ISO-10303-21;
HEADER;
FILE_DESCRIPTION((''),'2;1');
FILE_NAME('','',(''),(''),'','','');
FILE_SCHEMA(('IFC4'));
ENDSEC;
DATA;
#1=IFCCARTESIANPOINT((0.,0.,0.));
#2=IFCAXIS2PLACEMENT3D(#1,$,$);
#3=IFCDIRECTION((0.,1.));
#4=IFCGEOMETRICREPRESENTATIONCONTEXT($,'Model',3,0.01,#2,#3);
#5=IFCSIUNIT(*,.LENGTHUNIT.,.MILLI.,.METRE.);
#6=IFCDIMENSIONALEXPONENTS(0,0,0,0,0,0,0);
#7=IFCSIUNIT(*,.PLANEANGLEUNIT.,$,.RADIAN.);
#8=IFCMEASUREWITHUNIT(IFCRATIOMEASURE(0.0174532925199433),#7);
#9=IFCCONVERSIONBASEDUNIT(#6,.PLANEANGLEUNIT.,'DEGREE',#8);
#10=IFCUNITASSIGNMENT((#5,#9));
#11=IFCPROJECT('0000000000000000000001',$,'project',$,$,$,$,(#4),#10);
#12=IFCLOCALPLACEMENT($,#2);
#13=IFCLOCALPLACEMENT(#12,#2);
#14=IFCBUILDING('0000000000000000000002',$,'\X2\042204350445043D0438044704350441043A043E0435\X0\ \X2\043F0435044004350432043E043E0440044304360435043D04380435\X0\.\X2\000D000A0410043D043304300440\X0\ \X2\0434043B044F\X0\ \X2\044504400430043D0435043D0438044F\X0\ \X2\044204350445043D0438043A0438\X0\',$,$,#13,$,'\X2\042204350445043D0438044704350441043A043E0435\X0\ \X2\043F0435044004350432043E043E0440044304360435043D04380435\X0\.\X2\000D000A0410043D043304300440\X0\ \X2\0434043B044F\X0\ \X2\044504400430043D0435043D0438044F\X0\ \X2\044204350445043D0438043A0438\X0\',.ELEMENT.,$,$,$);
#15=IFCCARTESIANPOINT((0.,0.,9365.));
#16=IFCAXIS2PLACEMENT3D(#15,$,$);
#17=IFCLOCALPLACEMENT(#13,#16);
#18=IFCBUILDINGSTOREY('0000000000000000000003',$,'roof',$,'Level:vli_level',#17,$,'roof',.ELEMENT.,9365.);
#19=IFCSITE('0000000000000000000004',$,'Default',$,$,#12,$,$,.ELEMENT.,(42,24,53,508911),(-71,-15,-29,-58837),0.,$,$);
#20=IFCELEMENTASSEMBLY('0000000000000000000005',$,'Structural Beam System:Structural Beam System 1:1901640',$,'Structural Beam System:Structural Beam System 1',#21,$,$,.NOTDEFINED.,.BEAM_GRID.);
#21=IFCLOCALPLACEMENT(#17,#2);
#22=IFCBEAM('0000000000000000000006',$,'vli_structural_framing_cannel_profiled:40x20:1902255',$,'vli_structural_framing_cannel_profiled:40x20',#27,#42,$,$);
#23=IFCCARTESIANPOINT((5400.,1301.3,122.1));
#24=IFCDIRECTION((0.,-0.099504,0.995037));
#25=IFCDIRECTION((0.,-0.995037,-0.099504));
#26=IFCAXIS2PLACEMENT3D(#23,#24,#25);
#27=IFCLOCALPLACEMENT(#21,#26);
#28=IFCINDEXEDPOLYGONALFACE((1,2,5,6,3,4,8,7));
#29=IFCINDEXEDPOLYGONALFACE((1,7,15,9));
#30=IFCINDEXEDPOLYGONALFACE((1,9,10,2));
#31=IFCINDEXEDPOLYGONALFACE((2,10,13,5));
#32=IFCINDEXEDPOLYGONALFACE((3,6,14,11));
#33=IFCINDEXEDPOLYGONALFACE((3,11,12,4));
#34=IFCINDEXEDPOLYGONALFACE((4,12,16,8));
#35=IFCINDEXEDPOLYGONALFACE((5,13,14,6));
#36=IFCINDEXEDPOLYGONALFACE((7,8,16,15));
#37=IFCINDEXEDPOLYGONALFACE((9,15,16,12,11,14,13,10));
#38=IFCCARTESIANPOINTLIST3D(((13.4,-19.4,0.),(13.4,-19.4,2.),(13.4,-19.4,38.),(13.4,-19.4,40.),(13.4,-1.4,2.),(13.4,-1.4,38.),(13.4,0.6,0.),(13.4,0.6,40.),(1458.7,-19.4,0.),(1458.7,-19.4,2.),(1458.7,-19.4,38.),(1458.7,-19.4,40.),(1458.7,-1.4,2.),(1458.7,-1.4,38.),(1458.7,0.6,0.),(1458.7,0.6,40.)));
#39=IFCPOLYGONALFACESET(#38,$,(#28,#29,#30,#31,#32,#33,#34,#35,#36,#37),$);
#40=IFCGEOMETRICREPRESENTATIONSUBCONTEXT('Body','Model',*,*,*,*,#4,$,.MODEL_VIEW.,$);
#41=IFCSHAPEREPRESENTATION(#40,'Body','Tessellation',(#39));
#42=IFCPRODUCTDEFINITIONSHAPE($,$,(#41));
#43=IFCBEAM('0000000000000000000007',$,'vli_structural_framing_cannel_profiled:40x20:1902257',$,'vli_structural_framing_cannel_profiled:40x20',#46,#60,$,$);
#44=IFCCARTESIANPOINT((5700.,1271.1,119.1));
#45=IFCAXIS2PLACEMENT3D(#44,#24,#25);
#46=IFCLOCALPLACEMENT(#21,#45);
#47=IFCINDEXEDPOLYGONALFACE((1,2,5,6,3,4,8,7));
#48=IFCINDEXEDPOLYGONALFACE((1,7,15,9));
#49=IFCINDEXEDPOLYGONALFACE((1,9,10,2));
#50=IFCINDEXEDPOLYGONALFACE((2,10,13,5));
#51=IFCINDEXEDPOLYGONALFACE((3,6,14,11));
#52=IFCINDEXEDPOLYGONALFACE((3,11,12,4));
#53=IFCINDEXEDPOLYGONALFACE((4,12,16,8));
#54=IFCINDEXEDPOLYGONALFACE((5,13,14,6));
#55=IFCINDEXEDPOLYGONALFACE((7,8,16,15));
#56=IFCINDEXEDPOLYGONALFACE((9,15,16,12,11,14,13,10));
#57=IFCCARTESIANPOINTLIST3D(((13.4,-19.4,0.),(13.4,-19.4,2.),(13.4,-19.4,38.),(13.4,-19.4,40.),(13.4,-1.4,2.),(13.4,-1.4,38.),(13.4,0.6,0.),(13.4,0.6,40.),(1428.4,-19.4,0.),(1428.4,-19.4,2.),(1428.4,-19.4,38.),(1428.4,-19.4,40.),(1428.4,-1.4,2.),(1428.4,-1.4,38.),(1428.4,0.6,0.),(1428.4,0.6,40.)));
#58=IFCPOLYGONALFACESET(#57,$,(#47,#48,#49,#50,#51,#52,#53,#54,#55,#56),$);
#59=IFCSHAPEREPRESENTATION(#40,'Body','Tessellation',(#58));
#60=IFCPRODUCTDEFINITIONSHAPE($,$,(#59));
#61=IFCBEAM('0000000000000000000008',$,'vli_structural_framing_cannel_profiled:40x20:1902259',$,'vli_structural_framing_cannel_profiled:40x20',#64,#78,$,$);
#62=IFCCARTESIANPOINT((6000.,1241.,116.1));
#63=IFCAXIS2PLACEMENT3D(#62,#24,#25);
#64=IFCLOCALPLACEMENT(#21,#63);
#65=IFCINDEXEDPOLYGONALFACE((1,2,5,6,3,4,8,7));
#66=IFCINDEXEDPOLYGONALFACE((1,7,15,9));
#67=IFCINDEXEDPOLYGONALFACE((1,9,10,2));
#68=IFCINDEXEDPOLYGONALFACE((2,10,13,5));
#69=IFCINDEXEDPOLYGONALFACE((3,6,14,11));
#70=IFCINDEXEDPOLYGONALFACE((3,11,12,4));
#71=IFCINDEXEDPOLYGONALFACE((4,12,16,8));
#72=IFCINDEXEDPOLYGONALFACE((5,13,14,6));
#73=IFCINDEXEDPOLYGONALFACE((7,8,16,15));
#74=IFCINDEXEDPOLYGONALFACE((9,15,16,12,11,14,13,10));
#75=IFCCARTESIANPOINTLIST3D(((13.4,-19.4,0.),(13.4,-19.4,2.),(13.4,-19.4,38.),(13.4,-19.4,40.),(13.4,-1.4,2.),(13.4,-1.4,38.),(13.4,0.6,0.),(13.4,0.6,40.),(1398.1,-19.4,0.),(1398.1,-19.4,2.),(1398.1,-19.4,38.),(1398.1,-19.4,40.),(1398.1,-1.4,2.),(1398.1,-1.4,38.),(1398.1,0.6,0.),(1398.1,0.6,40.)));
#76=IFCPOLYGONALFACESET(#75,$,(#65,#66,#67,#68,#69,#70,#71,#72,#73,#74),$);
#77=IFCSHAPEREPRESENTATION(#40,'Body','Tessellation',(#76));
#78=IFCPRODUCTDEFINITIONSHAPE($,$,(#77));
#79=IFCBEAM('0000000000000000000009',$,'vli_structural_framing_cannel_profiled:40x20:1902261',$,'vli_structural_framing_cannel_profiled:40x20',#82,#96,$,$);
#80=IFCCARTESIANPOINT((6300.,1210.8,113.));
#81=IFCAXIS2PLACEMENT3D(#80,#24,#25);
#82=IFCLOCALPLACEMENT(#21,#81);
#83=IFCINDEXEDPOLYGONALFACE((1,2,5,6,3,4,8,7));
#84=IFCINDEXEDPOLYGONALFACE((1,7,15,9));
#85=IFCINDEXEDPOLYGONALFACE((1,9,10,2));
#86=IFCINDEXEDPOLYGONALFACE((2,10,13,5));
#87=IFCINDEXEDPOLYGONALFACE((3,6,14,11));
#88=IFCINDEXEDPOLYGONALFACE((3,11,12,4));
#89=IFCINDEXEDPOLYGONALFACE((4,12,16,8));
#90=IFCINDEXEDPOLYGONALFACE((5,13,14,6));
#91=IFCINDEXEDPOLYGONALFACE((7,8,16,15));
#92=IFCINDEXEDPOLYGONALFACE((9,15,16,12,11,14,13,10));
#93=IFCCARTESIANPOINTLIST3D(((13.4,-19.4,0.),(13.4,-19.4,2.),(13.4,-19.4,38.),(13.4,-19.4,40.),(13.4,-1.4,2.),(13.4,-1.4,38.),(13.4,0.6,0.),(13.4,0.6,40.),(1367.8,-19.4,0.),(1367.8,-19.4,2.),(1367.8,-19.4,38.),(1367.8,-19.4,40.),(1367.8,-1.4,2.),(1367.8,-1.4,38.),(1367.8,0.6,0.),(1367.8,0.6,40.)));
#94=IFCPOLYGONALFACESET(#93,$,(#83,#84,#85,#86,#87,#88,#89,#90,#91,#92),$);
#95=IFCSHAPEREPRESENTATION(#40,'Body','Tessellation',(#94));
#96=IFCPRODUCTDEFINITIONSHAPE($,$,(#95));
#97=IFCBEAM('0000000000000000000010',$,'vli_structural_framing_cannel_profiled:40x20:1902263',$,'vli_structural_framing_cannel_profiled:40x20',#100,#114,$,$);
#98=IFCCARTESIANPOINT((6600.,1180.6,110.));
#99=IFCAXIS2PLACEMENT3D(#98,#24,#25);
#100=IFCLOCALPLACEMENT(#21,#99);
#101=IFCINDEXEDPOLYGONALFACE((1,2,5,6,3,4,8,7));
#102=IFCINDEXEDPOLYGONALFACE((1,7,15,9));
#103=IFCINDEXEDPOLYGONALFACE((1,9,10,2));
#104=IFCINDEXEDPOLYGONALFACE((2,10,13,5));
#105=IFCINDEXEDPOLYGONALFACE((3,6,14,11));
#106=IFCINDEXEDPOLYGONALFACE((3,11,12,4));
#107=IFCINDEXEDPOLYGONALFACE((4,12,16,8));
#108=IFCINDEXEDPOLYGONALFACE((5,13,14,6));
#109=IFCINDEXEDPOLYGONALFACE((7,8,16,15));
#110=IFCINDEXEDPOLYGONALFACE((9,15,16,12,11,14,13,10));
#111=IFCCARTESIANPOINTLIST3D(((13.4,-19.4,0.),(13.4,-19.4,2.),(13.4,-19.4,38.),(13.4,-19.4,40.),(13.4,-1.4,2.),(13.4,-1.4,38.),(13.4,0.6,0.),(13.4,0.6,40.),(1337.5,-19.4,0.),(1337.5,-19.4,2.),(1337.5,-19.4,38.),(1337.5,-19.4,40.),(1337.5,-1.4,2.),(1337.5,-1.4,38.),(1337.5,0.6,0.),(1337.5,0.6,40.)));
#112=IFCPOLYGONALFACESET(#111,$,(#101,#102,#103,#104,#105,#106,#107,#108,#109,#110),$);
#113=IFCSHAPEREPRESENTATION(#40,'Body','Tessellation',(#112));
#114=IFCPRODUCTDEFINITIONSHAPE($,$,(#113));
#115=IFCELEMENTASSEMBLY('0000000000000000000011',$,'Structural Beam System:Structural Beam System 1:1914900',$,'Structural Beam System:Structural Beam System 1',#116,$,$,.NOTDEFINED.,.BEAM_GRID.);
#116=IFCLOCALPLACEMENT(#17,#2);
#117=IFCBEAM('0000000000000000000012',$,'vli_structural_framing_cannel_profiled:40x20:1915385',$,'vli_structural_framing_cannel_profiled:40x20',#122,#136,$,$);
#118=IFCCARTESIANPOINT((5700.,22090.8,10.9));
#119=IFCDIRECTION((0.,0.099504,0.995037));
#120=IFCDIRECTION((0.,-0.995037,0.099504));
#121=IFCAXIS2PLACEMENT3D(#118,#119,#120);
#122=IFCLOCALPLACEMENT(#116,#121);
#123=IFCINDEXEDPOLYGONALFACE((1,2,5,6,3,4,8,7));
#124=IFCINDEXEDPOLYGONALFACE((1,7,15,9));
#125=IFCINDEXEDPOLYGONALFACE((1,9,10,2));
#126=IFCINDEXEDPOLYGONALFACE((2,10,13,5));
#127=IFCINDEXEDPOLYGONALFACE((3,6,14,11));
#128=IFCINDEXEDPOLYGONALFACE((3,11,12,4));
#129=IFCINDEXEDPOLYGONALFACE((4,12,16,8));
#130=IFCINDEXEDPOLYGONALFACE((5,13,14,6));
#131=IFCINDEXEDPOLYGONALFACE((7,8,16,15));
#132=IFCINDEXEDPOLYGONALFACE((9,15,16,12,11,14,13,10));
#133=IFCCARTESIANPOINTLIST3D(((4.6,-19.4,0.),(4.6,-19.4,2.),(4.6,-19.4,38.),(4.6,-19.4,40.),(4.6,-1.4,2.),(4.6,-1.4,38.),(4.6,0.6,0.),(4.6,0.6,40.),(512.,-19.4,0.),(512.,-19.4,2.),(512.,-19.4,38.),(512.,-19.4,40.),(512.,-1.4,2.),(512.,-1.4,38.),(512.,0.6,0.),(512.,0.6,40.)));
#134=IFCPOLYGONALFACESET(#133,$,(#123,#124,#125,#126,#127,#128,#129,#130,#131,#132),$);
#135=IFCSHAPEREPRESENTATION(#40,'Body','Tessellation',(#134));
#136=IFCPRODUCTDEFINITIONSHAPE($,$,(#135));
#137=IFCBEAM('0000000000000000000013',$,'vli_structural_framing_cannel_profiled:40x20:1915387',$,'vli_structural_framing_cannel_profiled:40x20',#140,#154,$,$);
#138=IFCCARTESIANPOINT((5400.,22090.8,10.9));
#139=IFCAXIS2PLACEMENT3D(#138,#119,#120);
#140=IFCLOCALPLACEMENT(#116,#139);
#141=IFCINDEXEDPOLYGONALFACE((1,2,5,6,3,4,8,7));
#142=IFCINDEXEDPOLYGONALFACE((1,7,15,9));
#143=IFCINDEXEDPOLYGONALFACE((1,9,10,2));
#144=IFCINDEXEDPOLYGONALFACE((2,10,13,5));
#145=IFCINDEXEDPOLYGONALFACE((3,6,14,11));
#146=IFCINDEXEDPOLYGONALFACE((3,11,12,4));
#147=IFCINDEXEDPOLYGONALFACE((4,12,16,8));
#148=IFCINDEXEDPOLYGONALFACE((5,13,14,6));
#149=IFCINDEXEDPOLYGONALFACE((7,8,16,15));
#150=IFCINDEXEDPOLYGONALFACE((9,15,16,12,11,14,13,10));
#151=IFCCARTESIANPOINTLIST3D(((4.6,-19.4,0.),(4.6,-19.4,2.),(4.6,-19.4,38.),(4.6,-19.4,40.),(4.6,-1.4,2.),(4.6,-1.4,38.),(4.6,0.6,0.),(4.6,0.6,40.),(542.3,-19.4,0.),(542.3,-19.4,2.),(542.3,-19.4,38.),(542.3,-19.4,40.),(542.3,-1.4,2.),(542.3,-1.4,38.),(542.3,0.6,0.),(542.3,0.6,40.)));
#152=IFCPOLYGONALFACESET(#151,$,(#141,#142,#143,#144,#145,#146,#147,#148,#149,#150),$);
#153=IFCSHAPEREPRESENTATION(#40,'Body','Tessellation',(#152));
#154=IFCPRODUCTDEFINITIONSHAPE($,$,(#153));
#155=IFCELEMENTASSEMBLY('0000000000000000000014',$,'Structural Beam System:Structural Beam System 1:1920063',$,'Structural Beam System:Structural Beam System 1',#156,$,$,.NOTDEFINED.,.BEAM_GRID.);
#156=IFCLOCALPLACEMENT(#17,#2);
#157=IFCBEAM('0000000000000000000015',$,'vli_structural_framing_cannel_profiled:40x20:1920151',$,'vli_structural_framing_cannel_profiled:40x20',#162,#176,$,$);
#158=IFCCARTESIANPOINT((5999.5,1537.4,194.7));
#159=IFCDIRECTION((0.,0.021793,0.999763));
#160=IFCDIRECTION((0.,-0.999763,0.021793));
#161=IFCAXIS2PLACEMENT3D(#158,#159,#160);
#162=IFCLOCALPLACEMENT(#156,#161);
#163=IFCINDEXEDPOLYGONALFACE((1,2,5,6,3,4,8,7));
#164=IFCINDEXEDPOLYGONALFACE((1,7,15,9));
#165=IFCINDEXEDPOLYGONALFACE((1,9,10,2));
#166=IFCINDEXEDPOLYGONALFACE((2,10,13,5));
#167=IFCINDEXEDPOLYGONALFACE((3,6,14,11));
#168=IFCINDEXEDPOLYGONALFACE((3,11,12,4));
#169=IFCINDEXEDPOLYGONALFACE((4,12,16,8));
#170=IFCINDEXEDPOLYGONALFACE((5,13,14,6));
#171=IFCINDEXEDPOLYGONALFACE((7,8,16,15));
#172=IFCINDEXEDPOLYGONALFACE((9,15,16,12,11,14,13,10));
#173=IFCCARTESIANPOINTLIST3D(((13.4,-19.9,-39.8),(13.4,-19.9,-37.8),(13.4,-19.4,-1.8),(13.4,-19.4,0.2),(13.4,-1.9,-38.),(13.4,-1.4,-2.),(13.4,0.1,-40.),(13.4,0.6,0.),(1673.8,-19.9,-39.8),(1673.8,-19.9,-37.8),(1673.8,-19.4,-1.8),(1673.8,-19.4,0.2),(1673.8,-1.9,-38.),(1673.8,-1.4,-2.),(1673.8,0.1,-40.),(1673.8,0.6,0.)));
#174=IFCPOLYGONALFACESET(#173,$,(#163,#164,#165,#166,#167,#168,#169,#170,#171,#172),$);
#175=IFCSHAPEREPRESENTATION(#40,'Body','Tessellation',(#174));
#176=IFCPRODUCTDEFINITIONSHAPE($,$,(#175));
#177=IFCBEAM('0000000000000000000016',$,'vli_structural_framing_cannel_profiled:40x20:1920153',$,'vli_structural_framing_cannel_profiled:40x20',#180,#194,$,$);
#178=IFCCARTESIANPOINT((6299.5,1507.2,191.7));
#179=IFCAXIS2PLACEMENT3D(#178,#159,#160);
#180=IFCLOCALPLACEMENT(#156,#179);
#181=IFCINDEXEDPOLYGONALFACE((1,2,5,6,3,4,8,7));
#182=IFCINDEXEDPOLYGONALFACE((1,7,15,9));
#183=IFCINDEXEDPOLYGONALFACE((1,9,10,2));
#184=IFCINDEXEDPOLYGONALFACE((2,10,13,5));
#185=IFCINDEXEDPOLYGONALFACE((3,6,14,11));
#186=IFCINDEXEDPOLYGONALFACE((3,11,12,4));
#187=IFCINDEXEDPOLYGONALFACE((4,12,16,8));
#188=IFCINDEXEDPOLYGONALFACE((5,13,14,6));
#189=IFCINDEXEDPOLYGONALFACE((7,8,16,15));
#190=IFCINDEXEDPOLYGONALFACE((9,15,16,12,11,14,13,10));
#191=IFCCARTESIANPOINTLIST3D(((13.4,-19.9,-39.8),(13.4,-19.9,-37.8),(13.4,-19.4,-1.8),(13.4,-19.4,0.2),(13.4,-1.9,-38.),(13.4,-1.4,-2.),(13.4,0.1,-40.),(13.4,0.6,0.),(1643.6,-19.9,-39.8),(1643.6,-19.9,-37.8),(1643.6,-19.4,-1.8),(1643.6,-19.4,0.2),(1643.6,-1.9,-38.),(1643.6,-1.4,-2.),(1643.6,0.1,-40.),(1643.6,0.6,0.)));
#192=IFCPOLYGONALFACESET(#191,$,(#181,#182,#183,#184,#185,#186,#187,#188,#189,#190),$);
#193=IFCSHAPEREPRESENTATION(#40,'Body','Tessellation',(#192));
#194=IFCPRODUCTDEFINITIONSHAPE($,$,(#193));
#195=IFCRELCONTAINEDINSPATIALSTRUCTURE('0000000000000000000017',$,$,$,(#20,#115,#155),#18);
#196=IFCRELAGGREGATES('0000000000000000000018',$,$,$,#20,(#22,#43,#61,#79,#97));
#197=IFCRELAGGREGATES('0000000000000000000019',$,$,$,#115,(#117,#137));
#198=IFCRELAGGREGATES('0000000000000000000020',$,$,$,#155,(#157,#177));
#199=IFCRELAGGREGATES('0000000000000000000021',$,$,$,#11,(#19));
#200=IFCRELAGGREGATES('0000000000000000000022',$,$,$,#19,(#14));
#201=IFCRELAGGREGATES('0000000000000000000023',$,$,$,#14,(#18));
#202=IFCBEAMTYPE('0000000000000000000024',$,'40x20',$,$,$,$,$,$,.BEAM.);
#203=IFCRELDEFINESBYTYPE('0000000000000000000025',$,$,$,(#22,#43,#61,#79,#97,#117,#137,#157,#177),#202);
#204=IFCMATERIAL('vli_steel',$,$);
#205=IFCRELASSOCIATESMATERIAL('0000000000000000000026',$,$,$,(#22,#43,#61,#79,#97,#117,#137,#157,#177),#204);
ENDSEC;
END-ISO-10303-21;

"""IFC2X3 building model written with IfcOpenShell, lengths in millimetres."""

from ifc_helpers import new_model, entity, si_unit, converted_unit, direction, frame, origin, place, context, subcontext, project, spatial, polyline, outline, extrude, material, type_object, element, aggregate, save


model = new_model("IFC2X3")

# Units and contexts
model_context = context("Model", 3, precision=0.01, world=origin(), true_north=direction((0.0, 1.0)))
body_context = subcontext(model_context, "Body", "Model", "MODEL_VIEW")
ifc_project = project(units=[si_unit("LENGTHUNIT", "METRE", prefix="MILLI"), converted_unit("PLANEANGLEUNIT", "DEGREE", entity("IfcRatioMeasure", 0.0174532925199433), si_unit("PLANEANGLEUNIT", "RADIAN"), dimensions=[0, 0, 0, 0, 0, 0, 0])], contexts=[model_context])

# Site, building, storey
site_placement = place(None, origin())
site = spatial("IfcSite", under=ifc_project, at=site_placement, Name="Default", CompositionType="ELEMENT", RefLatitude=(42, 24, 53, 508911), RefLongitude=(-71, -15, -29, -58837), RefElevation=0.0)
building_placement = place(site_placement, origin())
building = spatial("IfcBuilding", under=site, at=building_placement, Name="Техническое перевооружение.\r\nАнгар для хранения техники", LongName="Техническое перевооружение.\r\nАнгар для хранения техники", CompositionType="ELEMENT")
storey_placement = place(building_placement, frame((0.0, 0.0, 9365.0)))
storey = spatial("IfcBuildingStorey", under=building, at=storey_placement, Name="roof", ObjectType="Level:vli_level", LongName="roof", CompositionType="ELEMENT", Elevation=9365.0)

# Element assemblies, beams
assembly_1_placement = place(storey_placement, origin())
assembly_1 = element("IfcElementAssembly", 1, at=assembly_1_placement, inside=storey, Name="Structural Beam System:Structural Beam System 1:1901640", ObjectType="Structural Beam System:Structural Beam System 1", AssemblyPlace="NOTDEFINED", PredefinedType="BEAM_GRID")
ifc_material = material(Name="vli_steel")
beam_type = type_object("IfcBeamType", Name="40x20", PredefinedType="BEAM")
beam_1_placement = place(assembly_1_placement, frame((5400.0, 1301.3, 122.1), z_axis=(0.0, -0.099504, 0.995037), x_axis=(0.0, -0.995037, -0.099504)))
beam_1 = element("IfcBeam", 2, at=beam_1_placement, type_object=beam_type, material=ifc_material, Name="vli_structural_framing_cannel_profiled:40x20:1902255", ObjectType="vli_structural_framing_cannel_profiled:40x20", context=body_context, shape_type="SweptSolid", body=[
    extrude(outline(polyline([(-20.0, -9.5), (-18.0, -9.5), (-18.0, 8.5), (18.0, 8.5), (18.0, -9.5), (20.0, -9.5), (20.0, 10.5), (-20.0, 10.5), (-20.0, -9.5)])), frame((13.4, -9.9, 20.0), z_axis=(1.0, 0.0, 0.0), x_axis=(0.0, 0.0, -1.0)), (0.0, 0.0, 1.0), 1445.4),
])
beam_2_placement = place(assembly_1_placement, frame((5700.0, 1271.1, 119.1), z_axis=(0.0, -0.099504, 0.995037), x_axis=(0.0, -0.995037, -0.099504)))
beam_2 = element("IfcBeam", 3, at=beam_2_placement, type_object=beam_type, material=ifc_material, Name="vli_structural_framing_cannel_profiled:40x20:1902257", ObjectType="vli_structural_framing_cannel_profiled:40x20", context=body_context, shape_type="SweptSolid", body=[
    extrude(outline(polyline([(-20.0, -9.5), (-18.0, -9.5), (-18.0, 8.5), (18.0, 8.5), (18.0, -9.5), (20.0, -9.5), (20.0, 10.5), (-20.0, 10.5), (-20.0, -9.5)])), frame((13.4, -9.9, 20.0), z_axis=(1.0, 0.0, 0.0), x_axis=(0.0, 0.0, -1.0)), (0.0, 0.0, 1.0), 1415.1),
])
beam_3_placement = place(assembly_1_placement, frame((6000.0, 1241.0, 116.1), z_axis=(0.0, -0.099504, 0.995037), x_axis=(0.0, -0.995037, -0.099504)))
beam_3 = element("IfcBeam", 4, at=beam_3_placement, type_object=beam_type, material=ifc_material, Name="vli_structural_framing_cannel_profiled:40x20:1902259", ObjectType="vli_structural_framing_cannel_profiled:40x20", context=body_context, shape_type="SweptSolid", body=[
    extrude(outline(polyline([(-20.0, -9.5), (-18.0, -9.5), (-18.0, 8.5), (18.0, 8.5), (18.0, -9.5), (20.0, -9.5), (20.0, 10.5), (-20.0, 10.5), (-20.0, -9.5)])), frame((13.4, -9.9, 20.0), z_axis=(1.0, 0.0, 0.0), x_axis=(0.0, 0.0, -1.0)), (0.0, 0.0, 1.0), 1384.8),
])
beam_4_placement = place(assembly_1_placement, frame((6300.0, 1210.8, 113.0), z_axis=(0.0, -0.099504, 0.995037), x_axis=(0.0, -0.995037, -0.099504)))
beam_4 = element("IfcBeam", 5, at=beam_4_placement, type_object=beam_type, material=ifc_material, Name="vli_structural_framing_cannel_profiled:40x20:1902261", ObjectType="vli_structural_framing_cannel_profiled:40x20", context=body_context, shape_type="SweptSolid", body=[
    extrude(outline(polyline([(-20.0, -9.5), (-18.0, -9.5), (-18.0, 8.5), (18.0, 8.5), (18.0, -9.5), (20.0, -9.5), (20.0, 10.5), (-20.0, 10.5), (-20.0, -9.5)])), frame((13.4, -9.9, 20.0), z_axis=(1.0, 0.0, 0.0), x_axis=(0.0, 0.0, -1.0)), (0.0, 0.0, 1.0), 1354.5),
])
beam_5_placement = place(assembly_1_placement, frame((6600.0, 1180.6, 110.0), z_axis=(0.0, -0.099504, 0.995037), x_axis=(0.0, -0.995037, -0.099504)))
beam_5 = element("IfcBeam", 6, at=beam_5_placement, type_object=beam_type, material=ifc_material, Name="vli_structural_framing_cannel_profiled:40x20:1902263", ObjectType="vli_structural_framing_cannel_profiled:40x20", context=body_context, shape_type="SweptSolid", body=[
    extrude(outline(polyline([(-20.0, -9.5), (-18.0, -9.5), (-18.0, 8.5), (18.0, 8.5), (18.0, -9.5), (20.0, -9.5), (20.0, 10.5), (-20.0, 10.5), (-20.0, -9.5)])), frame((13.4, -9.9, 20.0), z_axis=(1.0, 0.0, 0.0), x_axis=(0.0, 0.0, -1.0)), (0.0, 0.0, 1.0), 1324.2),
])
aggregate(assembly_1, [beam_1, beam_2, beam_3, beam_4, beam_5])
assembly_2_placement = place(storey_placement, origin())
assembly_2 = element("IfcElementAssembly", 7, at=assembly_2_placement, inside=storey, Name="Structural Beam System:Structural Beam System 1:1914900", ObjectType="Structural Beam System:Structural Beam System 1", AssemblyPlace="NOTDEFINED", PredefinedType="BEAM_GRID")
beam_6_placement = place(assembly_2_placement, frame((5700.0, 22090.8, 10.9), z_axis=(0.0, 0.099504, 0.995037), x_axis=(0.0, -0.995037, 0.099504)))
beam_6 = element("IfcBeam", 8, at=beam_6_placement, type_object=beam_type, material=ifc_material, Name="vli_structural_framing_cannel_profiled:40x20:1915385", ObjectType="vli_structural_framing_cannel_profiled:40x20", context=body_context, shape_type="SweptSolid", body=[
    extrude(outline(polyline([(-20.0, -9.5), (-18.0, -9.5), (-18.0, 8.5), (18.0, 8.5), (18.0, -9.5), (20.0, -9.5), (20.0, 10.5), (-20.0, 10.5), (-20.0, -9.5)])), frame((4.6, -9.9, 20.0), z_axis=(1.0, 0.0, 0.0), x_axis=(0.0, 0.0, -1.0)), (0.0, 0.0, 1.0), 507.4),
])
beam_7_placement = place(assembly_2_placement, frame((5400.0, 22090.8, 10.9), z_axis=(0.0, 0.099504, 0.995037), x_axis=(0.0, -0.995037, 0.099504)))
beam_7 = element("IfcBeam", 9, at=beam_7_placement, type_object=beam_type, material=ifc_material, Name="vli_structural_framing_cannel_profiled:40x20:1915387", ObjectType="vli_structural_framing_cannel_profiled:40x20", context=body_context, shape_type="SweptSolid", body=[
    extrude(outline(polyline([(-20.0, -9.5), (-18.0, -9.5), (-18.0, 8.5), (18.0, 8.5), (18.0, -9.5), (20.0, -9.5), (20.0, 10.5), (-20.0, 10.5), (-20.0, -9.5)])), frame((4.6, -9.9, 20.0), z_axis=(1.0, 0.0, 0.0), x_axis=(0.0, 0.0, -1.0)), (0.0, 0.0, 1.0), 537.7),
])
aggregate(assembly_2, [beam_6, beam_7])
assembly_3_placement = place(storey_placement, origin())
assembly_3 = element("IfcElementAssembly", 10, at=assembly_3_placement, inside=storey, Name="Structural Beam System:Structural Beam System 1:1920063", ObjectType="Structural Beam System:Structural Beam System 1", AssemblyPlace="NOTDEFINED", PredefinedType="BEAM_GRID")
beam_8_placement = place(assembly_3_placement, frame((5999.5, 1537.4, 194.7), z_axis=(0.0, 0.021793, 0.999763), x_axis=(0.0, -0.999763, 0.021793)))
beam_8 = element("IfcBeam", 11, at=beam_8_placement, type_object=beam_type, material=ifc_material, Name="vli_structural_framing_cannel_profiled:40x20:1920151", ObjectType="vli_structural_framing_cannel_profiled:40x20", context=body_context, shape_type="SweptSolid", body=[
    extrude(outline(polyline([(-10.5, -20.0), (9.5, -20.0), (9.5, -18.0), (-8.5, -18.0), (-8.5, 18.0), (9.5, 18.0), (9.5, 20.0), (-10.5, 20.0), (-10.5, -20.0)])), frame((13.4, -10.1, -19.9), z_axis=(1.0, 0.0, 0.0), x_axis=(0.0, -0.999925, 0.012237)), (0.0, 0.0, 1.0), 1660.4),
])
beam_9_placement = place(assembly_3_placement, frame((6299.5, 1507.2, 191.7), z_axis=(0.0, 0.021793, 0.999763), x_axis=(0.0, -0.999763, 0.021793)))
beam_9 = element("IfcBeam", 12, at=beam_9_placement, type_object=beam_type, material=ifc_material, Name="vli_structural_framing_cannel_profiled:40x20:1920153", ObjectType="vli_structural_framing_cannel_profiled:40x20", context=body_context, shape_type="SweptSolid", body=[
    extrude(outline(polyline([(-10.5, -20.0), (9.5, -20.0), (9.5, -18.0), (-8.5, -18.0), (-8.5, 18.0), (9.5, 18.0), (9.5, 20.0), (-10.5, 20.0), (-10.5, -20.0)])), frame((13.4, -10.1, -19.9), z_axis=(1.0, 0.0, 0.0), x_axis=(0.0, -0.999925, 0.012237)), (0.0, 0.0, 1.0), 1630.2),
])
aggregate(assembly_3, [beam_8, beam_9])

save(model, "model.ifc")
